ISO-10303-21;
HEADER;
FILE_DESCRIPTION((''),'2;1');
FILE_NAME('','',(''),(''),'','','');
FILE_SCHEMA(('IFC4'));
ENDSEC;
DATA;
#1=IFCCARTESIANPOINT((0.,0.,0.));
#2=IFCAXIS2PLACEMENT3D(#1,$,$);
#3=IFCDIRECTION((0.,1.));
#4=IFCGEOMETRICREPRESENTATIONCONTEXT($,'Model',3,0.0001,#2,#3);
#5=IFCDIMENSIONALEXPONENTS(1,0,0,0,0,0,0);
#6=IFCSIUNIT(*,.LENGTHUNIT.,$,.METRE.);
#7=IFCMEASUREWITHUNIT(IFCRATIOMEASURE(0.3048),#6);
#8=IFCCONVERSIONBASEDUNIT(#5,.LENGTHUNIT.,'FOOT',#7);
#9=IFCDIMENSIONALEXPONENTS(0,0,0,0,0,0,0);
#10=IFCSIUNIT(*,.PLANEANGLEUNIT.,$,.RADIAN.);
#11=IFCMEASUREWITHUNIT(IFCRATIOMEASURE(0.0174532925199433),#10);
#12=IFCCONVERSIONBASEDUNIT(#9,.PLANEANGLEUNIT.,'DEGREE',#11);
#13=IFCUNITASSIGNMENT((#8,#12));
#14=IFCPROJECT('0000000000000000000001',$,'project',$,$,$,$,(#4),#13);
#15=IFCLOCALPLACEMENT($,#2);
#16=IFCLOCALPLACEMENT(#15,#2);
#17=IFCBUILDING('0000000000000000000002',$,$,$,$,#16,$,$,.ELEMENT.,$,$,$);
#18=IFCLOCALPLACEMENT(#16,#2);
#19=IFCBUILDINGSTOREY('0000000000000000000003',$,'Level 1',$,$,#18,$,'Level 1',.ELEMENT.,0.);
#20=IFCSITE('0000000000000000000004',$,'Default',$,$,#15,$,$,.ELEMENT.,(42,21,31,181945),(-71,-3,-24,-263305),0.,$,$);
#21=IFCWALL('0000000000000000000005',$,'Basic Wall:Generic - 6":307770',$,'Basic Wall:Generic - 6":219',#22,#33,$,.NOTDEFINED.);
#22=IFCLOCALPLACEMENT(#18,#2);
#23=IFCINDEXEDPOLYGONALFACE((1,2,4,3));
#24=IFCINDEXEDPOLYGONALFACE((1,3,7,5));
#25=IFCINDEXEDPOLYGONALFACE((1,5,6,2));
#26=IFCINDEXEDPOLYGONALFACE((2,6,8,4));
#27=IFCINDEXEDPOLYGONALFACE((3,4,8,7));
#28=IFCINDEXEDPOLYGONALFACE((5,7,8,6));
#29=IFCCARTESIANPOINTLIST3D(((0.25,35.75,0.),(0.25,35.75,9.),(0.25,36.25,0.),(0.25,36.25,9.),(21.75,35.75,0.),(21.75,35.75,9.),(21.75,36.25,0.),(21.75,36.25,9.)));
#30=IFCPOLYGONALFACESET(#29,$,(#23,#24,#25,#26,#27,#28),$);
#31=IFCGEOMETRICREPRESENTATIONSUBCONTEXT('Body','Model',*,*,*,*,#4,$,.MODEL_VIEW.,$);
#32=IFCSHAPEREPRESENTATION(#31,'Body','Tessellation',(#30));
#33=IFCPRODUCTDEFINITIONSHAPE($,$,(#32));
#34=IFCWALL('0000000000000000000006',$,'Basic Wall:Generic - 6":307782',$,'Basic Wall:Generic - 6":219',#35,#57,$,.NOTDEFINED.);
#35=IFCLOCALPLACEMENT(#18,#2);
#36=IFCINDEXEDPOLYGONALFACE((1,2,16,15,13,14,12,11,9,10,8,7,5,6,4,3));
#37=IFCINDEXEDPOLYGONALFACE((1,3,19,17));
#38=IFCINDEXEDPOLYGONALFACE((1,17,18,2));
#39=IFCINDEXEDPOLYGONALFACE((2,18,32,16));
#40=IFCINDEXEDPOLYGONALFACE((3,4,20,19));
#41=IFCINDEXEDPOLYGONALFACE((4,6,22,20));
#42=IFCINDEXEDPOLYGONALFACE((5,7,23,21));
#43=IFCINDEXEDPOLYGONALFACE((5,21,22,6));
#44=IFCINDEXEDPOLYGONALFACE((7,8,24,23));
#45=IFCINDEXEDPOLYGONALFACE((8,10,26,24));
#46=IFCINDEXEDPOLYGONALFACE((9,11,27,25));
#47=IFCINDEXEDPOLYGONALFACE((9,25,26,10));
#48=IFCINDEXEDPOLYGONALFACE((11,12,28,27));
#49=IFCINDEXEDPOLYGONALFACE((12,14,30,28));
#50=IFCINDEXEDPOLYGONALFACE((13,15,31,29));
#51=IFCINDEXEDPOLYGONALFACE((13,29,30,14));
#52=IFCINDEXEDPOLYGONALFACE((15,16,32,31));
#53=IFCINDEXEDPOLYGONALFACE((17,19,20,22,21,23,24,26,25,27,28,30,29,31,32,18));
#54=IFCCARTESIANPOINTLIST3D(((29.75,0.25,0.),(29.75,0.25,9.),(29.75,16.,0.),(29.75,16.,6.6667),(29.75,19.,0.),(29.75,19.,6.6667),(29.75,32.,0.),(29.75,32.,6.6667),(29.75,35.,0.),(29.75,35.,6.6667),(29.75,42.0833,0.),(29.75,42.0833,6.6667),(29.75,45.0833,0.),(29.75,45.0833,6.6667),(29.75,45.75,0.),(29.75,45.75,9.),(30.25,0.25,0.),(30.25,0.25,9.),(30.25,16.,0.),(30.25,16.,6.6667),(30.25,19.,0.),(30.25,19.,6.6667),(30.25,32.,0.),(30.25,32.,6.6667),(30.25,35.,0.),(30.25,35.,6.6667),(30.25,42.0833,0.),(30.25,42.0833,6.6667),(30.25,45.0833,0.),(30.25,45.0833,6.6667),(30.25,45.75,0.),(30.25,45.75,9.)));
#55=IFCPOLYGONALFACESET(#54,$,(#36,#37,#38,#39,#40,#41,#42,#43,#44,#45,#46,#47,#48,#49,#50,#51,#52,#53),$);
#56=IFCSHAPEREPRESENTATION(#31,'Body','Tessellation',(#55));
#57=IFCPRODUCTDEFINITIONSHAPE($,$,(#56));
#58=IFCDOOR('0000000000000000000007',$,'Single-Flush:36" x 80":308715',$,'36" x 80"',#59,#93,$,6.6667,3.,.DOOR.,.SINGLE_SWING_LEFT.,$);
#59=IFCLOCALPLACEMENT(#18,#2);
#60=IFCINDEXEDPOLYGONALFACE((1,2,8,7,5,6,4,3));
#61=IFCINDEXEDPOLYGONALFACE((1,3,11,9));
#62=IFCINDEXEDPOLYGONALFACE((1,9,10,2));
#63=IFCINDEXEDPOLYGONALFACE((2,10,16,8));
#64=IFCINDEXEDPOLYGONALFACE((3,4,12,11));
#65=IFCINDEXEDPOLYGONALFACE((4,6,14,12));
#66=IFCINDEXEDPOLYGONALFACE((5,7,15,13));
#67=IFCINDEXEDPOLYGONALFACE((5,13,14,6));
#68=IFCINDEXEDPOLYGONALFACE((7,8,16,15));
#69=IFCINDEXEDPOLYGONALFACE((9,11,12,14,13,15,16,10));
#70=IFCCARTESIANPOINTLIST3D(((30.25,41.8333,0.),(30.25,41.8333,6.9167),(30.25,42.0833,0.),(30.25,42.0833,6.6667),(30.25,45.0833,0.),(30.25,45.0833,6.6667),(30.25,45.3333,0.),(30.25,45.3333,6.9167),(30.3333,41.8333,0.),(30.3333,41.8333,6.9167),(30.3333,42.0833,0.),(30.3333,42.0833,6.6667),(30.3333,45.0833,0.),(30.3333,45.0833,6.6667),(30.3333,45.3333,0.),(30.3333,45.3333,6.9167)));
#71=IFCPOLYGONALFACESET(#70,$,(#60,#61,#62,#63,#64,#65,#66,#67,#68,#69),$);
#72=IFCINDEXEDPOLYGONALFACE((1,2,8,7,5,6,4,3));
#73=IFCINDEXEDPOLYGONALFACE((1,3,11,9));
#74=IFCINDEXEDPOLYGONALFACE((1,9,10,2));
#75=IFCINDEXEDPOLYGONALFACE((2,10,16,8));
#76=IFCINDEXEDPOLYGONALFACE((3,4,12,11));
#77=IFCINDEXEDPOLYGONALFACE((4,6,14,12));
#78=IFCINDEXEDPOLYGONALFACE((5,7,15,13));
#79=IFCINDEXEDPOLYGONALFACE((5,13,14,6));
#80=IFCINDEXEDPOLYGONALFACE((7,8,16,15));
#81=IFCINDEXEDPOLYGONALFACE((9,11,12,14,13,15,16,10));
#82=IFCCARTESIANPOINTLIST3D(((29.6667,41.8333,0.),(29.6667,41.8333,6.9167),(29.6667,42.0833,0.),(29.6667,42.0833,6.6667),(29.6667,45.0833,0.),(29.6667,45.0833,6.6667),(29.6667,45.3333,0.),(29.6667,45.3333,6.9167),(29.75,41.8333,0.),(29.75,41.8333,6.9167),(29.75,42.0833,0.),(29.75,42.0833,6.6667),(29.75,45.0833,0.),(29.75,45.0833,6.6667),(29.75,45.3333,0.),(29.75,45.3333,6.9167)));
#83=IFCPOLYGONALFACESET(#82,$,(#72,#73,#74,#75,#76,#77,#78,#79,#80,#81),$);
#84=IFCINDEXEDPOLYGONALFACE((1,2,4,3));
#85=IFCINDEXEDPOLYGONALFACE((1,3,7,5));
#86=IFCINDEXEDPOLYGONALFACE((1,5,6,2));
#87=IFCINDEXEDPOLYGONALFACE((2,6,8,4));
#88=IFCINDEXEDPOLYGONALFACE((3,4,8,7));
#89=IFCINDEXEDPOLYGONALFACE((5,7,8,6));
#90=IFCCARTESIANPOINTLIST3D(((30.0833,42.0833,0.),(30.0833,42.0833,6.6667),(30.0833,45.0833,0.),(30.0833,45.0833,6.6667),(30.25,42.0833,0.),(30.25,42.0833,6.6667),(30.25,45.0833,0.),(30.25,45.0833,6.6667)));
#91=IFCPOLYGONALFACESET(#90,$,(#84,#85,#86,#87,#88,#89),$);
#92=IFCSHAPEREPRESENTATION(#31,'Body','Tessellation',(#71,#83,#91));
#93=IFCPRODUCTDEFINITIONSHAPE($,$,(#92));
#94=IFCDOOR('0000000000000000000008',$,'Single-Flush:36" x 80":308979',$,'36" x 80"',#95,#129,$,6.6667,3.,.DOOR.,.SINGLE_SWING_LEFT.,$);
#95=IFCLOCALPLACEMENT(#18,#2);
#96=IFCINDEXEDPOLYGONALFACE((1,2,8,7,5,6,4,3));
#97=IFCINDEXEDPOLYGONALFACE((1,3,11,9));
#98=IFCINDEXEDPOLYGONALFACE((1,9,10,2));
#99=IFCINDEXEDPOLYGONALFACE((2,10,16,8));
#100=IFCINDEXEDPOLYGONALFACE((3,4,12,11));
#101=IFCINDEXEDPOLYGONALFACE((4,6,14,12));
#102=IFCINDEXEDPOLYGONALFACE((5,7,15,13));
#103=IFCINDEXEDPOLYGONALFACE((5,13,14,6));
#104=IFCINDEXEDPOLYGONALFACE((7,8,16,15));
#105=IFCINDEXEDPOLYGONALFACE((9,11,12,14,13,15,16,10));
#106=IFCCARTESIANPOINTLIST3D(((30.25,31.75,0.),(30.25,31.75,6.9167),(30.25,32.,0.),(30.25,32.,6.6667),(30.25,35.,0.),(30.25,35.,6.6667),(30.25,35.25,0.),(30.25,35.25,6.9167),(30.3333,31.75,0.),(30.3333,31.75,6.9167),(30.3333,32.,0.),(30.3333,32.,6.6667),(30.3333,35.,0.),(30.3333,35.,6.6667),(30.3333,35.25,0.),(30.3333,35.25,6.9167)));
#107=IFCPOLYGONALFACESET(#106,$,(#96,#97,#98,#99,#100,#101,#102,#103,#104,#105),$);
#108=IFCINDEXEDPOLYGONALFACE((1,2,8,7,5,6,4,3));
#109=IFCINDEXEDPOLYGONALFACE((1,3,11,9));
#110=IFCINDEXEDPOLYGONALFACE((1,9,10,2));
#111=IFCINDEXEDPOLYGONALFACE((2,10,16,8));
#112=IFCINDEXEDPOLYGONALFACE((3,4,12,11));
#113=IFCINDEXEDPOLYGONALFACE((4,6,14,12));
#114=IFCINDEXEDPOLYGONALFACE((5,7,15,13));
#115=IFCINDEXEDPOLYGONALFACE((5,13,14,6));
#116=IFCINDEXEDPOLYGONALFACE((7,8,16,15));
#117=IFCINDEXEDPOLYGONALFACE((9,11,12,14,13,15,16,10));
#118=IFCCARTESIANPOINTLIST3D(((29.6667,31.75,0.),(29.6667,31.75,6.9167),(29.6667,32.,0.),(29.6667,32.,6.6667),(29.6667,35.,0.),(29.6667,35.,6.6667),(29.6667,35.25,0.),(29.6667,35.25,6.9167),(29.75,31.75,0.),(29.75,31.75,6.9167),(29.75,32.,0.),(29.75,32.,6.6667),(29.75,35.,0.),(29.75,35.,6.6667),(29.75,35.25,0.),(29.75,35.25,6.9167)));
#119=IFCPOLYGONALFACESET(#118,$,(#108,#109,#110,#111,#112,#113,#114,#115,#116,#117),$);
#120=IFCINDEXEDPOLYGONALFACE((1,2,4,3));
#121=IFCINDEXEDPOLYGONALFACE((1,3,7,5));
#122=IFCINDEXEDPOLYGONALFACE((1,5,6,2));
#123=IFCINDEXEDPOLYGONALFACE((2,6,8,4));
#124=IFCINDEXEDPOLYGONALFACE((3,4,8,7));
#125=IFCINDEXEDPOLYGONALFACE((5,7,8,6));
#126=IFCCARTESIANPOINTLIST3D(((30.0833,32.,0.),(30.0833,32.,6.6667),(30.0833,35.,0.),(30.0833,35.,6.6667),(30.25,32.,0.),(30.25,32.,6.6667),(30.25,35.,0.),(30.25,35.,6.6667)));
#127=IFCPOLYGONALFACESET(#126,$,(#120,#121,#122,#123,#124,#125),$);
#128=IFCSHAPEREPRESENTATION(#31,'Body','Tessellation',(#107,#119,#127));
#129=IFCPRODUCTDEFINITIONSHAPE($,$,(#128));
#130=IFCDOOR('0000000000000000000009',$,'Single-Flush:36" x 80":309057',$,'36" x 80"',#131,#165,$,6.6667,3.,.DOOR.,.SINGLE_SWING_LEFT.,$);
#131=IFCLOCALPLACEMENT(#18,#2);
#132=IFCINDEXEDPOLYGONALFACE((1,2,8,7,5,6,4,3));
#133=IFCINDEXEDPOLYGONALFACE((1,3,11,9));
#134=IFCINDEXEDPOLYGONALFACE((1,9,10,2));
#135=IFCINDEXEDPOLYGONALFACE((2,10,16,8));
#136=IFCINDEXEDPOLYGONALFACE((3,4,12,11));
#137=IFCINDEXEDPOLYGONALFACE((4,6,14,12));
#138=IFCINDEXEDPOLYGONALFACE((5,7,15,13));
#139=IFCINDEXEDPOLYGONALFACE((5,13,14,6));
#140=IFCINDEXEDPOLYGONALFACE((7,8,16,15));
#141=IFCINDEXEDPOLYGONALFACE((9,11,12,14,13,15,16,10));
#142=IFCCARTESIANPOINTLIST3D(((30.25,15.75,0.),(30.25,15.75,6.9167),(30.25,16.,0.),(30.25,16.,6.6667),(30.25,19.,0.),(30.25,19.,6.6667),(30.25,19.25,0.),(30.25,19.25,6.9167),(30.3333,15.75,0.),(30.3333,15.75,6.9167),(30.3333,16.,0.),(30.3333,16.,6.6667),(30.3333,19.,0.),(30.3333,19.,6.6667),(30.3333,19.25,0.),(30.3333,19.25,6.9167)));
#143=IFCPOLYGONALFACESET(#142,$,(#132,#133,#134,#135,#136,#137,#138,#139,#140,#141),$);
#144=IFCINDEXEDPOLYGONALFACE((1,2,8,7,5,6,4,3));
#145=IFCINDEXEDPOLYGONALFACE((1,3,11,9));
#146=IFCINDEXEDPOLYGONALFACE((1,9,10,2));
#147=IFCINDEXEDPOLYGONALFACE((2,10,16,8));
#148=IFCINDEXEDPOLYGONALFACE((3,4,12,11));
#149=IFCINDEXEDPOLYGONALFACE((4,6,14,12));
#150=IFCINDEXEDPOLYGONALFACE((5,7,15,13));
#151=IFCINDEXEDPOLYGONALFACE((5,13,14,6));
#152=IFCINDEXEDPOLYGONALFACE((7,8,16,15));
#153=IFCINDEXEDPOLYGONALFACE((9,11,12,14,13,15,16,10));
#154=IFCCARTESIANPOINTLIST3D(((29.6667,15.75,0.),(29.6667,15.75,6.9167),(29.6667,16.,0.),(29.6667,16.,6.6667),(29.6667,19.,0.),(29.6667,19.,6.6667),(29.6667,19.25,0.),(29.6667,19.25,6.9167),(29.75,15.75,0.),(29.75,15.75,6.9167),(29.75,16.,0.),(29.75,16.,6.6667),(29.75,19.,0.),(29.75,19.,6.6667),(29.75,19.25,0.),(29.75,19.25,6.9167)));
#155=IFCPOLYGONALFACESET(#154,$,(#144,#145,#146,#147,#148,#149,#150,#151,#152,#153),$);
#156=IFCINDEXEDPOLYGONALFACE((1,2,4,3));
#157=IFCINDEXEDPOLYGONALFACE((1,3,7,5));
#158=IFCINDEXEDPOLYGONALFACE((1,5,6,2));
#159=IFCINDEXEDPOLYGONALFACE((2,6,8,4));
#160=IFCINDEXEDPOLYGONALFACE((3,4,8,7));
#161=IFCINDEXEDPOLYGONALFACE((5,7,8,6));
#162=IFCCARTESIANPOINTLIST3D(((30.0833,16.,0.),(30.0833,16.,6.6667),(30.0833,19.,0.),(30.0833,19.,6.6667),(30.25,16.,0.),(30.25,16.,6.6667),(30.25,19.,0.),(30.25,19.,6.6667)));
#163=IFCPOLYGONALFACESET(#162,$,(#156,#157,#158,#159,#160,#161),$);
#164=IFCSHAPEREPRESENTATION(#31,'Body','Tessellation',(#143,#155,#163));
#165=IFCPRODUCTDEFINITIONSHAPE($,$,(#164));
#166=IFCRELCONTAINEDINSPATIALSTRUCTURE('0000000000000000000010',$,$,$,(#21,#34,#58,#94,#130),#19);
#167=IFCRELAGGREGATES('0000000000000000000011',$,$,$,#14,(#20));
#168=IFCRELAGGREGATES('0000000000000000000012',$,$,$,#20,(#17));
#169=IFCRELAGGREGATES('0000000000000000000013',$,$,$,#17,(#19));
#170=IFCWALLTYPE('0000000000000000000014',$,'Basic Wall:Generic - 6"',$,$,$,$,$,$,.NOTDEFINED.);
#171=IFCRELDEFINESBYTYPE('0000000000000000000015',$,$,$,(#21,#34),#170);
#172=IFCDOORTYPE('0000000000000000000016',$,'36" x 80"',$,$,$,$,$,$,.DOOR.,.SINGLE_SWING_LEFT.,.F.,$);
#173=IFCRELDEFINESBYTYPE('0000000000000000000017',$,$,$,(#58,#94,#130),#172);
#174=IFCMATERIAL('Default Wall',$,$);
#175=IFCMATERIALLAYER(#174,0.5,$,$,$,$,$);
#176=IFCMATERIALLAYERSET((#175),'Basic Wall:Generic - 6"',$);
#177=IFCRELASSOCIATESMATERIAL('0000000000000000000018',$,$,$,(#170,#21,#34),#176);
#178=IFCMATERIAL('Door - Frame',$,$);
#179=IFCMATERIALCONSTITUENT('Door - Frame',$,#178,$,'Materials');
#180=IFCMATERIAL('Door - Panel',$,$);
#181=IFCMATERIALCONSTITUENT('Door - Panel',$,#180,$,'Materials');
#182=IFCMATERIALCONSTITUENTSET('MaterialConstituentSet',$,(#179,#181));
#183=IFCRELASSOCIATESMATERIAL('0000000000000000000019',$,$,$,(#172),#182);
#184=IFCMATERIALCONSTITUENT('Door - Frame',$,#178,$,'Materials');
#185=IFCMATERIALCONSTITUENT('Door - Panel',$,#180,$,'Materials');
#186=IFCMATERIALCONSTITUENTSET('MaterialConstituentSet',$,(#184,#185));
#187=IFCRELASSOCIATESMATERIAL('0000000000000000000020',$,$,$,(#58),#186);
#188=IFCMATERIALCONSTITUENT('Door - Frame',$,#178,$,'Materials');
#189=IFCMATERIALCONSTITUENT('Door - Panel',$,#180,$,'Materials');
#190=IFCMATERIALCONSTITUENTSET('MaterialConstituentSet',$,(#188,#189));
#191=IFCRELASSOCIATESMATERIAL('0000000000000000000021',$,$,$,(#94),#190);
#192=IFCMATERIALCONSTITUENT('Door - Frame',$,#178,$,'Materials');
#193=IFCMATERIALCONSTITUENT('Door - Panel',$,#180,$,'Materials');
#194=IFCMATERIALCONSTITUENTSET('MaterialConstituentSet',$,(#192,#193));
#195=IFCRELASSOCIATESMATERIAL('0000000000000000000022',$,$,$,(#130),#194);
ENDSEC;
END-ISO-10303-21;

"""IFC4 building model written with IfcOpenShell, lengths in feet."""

from ifc_helpers import new_model, entity, si_unit, converted_unit, direction, frame, frame_2d, origin, origin_2d_with_axis, place, context, subcontext, project, spatial, polyline, rectangle, outline, extrude, clip, bounded_halfspace, source, transform, mapped, material, layer, layer_set, layer_usage, constituent, constituent_set, type_object, type_shapes, element, fill, save


model = new_model("IFC4")

# Units and contexts
model_context = context("Model", 3, precision=0.0001, world=origin(), true_north=direction((0.0, 1.0)))
body_context = subcontext(model_context, "Body", "Model", "MODEL_VIEW")
ifc_project = project(units=[converted_unit("LENGTHUNIT", "FOOT", entity("IfcRatioMeasure", 0.3048), si_unit("LENGTHUNIT", "METRE"), dimensions=[1, 0, 0, 0, 0, 0, 0]), converted_unit("PLANEANGLEUNIT", "DEGREE", entity("IfcRatioMeasure", 0.0174532925199433), si_unit("PLANEANGLEUNIT", "RADIAN"), dimensions=[0, 0, 0, 0, 0, 0, 0])], contexts=[model_context])

# Site, building, storey
site_placement = place(None, origin())
site = spatial("IfcSite", under=ifc_project, at=site_placement, Name="Default", CompositionType="ELEMENT", RefLatitude=(42, 21, 31, 181945), RefLongitude=(-71, -3, -24, -263305), RefElevation=0.0)
building_placement = place(site_placement, origin())
building = spatial("IfcBuilding", under=site, at=building_placement, CompositionType="ELEMENT")
storey_placement = place(building_placement, origin())
storey = spatial("IfcBuildingStorey", under=building, at=storey_placement, Name="Level 1", LongName="Level 1", CompositionType="ELEMENT", Elevation=0.0)

# Shared definitions
ifc_material_1 = material(Name="Default Wall")
ifc_layer = layer(ifc_material_1, 0.5)
ifc_layer_set = layer_set([ifc_layer], Name="Basic Wall:Generic - 6\"")
wall_type = type_object("IfcWallType", Name="Basic Wall:Generic - 6\"", PredefinedType="NOTDEFINED", material=ifc_layer_set)
ifc_material_2 = material(Name="Door - Frame")
ifc_material_3 = material(Name="Door - Panel")

# Wall
ifc_layer_usage_1 = layer_usage(ifc_layer_set, "AXIS2", "NEGATIVE", 0.25)
wall_1_placement = place(storey_placement, frame((0.25, 36.0, 0.0)))
element("IfcWall", 1, at=wall_1_placement, inside=storey, type_object=wall_type, material=ifc_layer_usage_1, Name="Basic Wall:Generic - 6\":307770", ObjectType="Basic Wall:Generic - 6\":219", PredefinedType="NOTDEFINED", context=body_context, shape_type="Clipping", body=[
    clip(extrude(rectangle(XDim=21.5, YDim=0.5, at=frame_2d((10.75, 0.0), x_axis=(-1.0, 0.0))), origin(), (0.0, 0.0, 1.0), 9.0), bounded_halfspace(frame((0.0, -0.25, 9.0), z_axis=(0.0, 0.0, -1.0), x_axis=(-1.0, 0.0, 0.0)), True, frame((0.0, -0.25, 9.0)), polyline([(0.0, 0.0), (21.5, 0.0), (21.5, 0.5), (0.0, 0.5), (0.0, 0.0)]))),
])

# Wall, openings, doors
ifc_layer_usage_2 = layer_usage(ifc_layer_set, "AXIS2", "NEGATIVE", 0.25)
wall_2_placement = place(storey_placement, frame((30.0, 45.75, 0.0), z_axis=(0.0, 0.0, 1.0), x_axis=(0.0, -1.0, 0.0)))
wall_2 = element("IfcWall", 2, at=wall_2_placement, inside=storey, type_object=wall_type, material=ifc_layer_usage_2, Name="Basic Wall:Generic - 6\":307782", ObjectType="Basic Wall:Generic - 6\":219", PredefinedType="NOTDEFINED", context=body_context, shape_type="Clipping", body=[
    clip(clip(extrude(rectangle(XDim=45.5, YDim=0.5, at=frame_2d((22.75, 0.0), x_axis=(-1.0, 0.0))), origin(), (0.0, 0.0, 1.0), 9.0), bounded_halfspace(frame((34.0, -0.25, 9.0), z_axis=(0.0, 0.0, -1.0), x_axis=(0.0, 1.0, 0.0)), True, frame((34.0, -0.25, 9.0)), polyline([(0.0, 0.0), (11.5, 0.0), (11.5, 0.5), (0.0, 0.5), (0.0, 0.0)]))), bounded_halfspace(frame((34.0, -0.25, 9.0), z_axis=(0.0, 0.0, -1.0), x_axis=(-1.0, 0.0, 0.0)), True, frame((34.0, -0.25, 9.0)), polyline([(0.0, 0.0), (0.0, 0.5), (-8.0, 0.5), (-8.5, 0.5), (-24.0, 0.5), (-24.5, 0.5), (-34.0, 0.5), (-34.0, 0.0), (-0.5, 0.0), (0.0, 0.0)]))),
])
opening_1_placement = place(wall_2_placement, frame((0.6667, -0.25, 0.0)))
opening_1 = element("IfcOpeningElement", 3, at=opening_1_placement, cuts=wall_2, ObjectType="Opening", PredefinedType="OPENING", context=body_context, shape_type="SweptSolid", body=[
    extrude(rectangle(XDim=3.0, YDim=6.6667, at=frame_2d((3.3333, 1.5), x_axis=(0.0, -1.0))), frame((0.0, 0.0, 0.0), z_axis=(0.0, 1.0, 0.0), x_axis=(0.0, 0.0, 1.0)), (0.0, 0.0, 1.0), 0.5),
])
opening_2_placement = place(wall_2_placement, frame((10.75, -0.25, 0.0)))
opening_2 = element("IfcOpeningElement", 4, at=opening_2_placement, cuts=wall_2, ObjectType="Opening", PredefinedType="OPENING", context=body_context, shape_type="SweptSolid", body=[
    extrude(rectangle(XDim=3.0, YDim=6.6667, at=frame_2d((3.3333, 1.5), x_axis=(0.0, -1.0))), frame((0.0, 0.0, 0.0), z_axis=(0.0, 1.0, 0.0), x_axis=(0.0, 0.0, 1.0)), (0.0, 0.0, 1.0), 0.5),
])
opening_3_placement = place(wall_2_placement, frame((26.75, -0.25, 0.0)))
opening_3 = element("IfcOpeningElement", 5, at=opening_3_placement, cuts=wall_2, ObjectType="Opening", PredefinedType="OPENING", context=body_context, shape_type="SweptSolid", body=[
    extrude(rectangle(XDim=3.0, YDim=6.6667, at=frame_2d((3.3333, 1.5), x_axis=(0.0, -1.0))), frame((0.0, 0.0, 0.0), z_axis=(0.0, 1.0, 0.0), x_axis=(0.0, 0.0, 1.0)), (0.0, 0.0, 1.0), 0.5),
])
ifc_constituent_1 = constituent(ifc_material_2, Name="Door - Frame", Category="Materials")
ifc_constituent_2 = constituent(ifc_material_3, Name="Door - Panel", Category="Materials")
ifc_constituent_set_1 = constituent_set(constituents=[ifc_constituent_1, ifc_constituent_2], Name="MaterialConstituentSet")
ifc_constituent_3 = constituent(ifc_material_2, Name="Door - Frame", Category="Materials")
ifc_constituent_4 = constituent(ifc_material_3, Name="Door - Panel", Category="Materials")
ifc_constituent_set_2 = constituent_set(constituents=[ifc_constituent_3, ifc_constituent_4], Name="MaterialConstituentSet")
door_type_1 = type_object("IfcDoorType", Name="36\" x 80\"", OperationType="SINGLE_SWING_LEFT", ParameterTakesPrecedence=False, PredefinedType="DOOR", material=ifc_constituent_set_2)
shared_shape_1 = source(origin(), body_context, "Body", "SweptSolid", [
    extrude(outline(polyline([(-1.75, -3.5208), (1.75, -3.5208), (1.75, 3.3958), (1.5, 3.3958), (1.5, -3.2708), (-1.5, -3.2708), (-1.5, 3.3958), (-1.75, 3.3958), (-1.75, -3.5208)])), frame((1.5, 0.5833, 3.3958), z_axis=(0.0, -1.0, 0.0), x_axis=(-1.0, 0.0, 0.0)), (0.0, 0.0, 1.0), 0.0833),
    extrude(outline(polyline([(-3.5208, -1.75), (3.3958, -1.75), (3.3958, -1.5), (-3.2708, -1.5), (-3.2708, 1.5), (3.3958, 1.5), (3.3958, 1.75), (-3.5208, 1.75), (-3.5208, -1.75)])), frame((1.5, 0.0, 3.3958), z_axis=(0.0, -1.0, 0.0), x_axis=(0.0, 0.0, -1.0)), (0.0, 0.0, 1.0), 0.0833),
    extrude(rectangle(XDim=3.0, YDim=0.1667, at=origin_2d_with_axis()), frame((1.5, 0.4167, 0.0)), (0.0, 0.0, 1.0), 6.6667),
])
type_shapes(door_type_1, [shared_shape_1])
door_1_placement = place(opening_1_placement, origin())
door_1 = element("IfcDoor", 6, at=door_1_placement, inside=storey, type_object=door_type_1, material=ifc_constituent_set_1, Name="Single-Flush:36\" x 80\":308715", ObjectType="36\" x 80\"", OperationType="SINGLE_SWING_LEFT", OverallHeight=6.6667, OverallWidth=3.0, PredefinedType="DOOR", context=body_context, shape_type="MappedRepresentation", body=[
    mapped(shared_shape_1, transform((0.0, 0.0, 0.0), scale=1.0)),
])
fill(opening_1, door_1)
ifc_constituent_5 = constituent(ifc_material_2, Name="Door - Frame", Category="Materials")
ifc_constituent_6 = constituent(ifc_material_3, Name="Door - Panel", Category="Materials")
ifc_constituent_set_3 = constituent_set(constituents=[ifc_constituent_5, ifc_constituent_6], Name="MaterialConstituentSet")
door_2_placement = place(opening_2_placement, origin())
door_2 = element("IfcDoor", 7, at=door_2_placement, inside=storey, type_object=door_type_1, material=ifc_constituent_set_3, Name="Single-Flush:36\" x 80\":308979", ObjectType="36\" x 80\"", OperationType="SINGLE_SWING_LEFT", OverallHeight=6.6667, OverallWidth=3.0, PredefinedType="DOOR", context=body_context, shape_type="MappedRepresentation", body=[
    mapped(shared_shape_1, transform((0.0, 0.0, 0.0), scale=1.0)),
])
fill(opening_2, door_2)
ifc_constituent_7 = constituent(ifc_material_2, Name="Door - Frame", Category="Materials")
ifc_constituent_8 = constituent(ifc_material_3, Name="Door - Panel", Category="Materials")
ifc_constituent_set_4 = constituent_set(constituents=[ifc_constituent_7, ifc_constituent_8], Name="MaterialConstituentSet")
door_3_placement = place(opening_3_placement, origin())
door_3 = element("IfcDoor", 8, at=door_3_placement, inside=storey, type_object=door_type_1, material=ifc_constituent_set_4, Name="Single-Flush:36\" x 80\":309057", ObjectType="36\" x 80\"", OperationType="SINGLE_SWING_LEFT", OverallHeight=6.6667, OverallWidth=3.0, PredefinedType="DOOR", context=body_context, shape_type="MappedRepresentation", body=[
    mapped(shared_shape_1, transform((0.0, 0.0, 0.0), scale=1.0)),
])
fill(opening_3, door_3)

save(model, "model.ifc")
